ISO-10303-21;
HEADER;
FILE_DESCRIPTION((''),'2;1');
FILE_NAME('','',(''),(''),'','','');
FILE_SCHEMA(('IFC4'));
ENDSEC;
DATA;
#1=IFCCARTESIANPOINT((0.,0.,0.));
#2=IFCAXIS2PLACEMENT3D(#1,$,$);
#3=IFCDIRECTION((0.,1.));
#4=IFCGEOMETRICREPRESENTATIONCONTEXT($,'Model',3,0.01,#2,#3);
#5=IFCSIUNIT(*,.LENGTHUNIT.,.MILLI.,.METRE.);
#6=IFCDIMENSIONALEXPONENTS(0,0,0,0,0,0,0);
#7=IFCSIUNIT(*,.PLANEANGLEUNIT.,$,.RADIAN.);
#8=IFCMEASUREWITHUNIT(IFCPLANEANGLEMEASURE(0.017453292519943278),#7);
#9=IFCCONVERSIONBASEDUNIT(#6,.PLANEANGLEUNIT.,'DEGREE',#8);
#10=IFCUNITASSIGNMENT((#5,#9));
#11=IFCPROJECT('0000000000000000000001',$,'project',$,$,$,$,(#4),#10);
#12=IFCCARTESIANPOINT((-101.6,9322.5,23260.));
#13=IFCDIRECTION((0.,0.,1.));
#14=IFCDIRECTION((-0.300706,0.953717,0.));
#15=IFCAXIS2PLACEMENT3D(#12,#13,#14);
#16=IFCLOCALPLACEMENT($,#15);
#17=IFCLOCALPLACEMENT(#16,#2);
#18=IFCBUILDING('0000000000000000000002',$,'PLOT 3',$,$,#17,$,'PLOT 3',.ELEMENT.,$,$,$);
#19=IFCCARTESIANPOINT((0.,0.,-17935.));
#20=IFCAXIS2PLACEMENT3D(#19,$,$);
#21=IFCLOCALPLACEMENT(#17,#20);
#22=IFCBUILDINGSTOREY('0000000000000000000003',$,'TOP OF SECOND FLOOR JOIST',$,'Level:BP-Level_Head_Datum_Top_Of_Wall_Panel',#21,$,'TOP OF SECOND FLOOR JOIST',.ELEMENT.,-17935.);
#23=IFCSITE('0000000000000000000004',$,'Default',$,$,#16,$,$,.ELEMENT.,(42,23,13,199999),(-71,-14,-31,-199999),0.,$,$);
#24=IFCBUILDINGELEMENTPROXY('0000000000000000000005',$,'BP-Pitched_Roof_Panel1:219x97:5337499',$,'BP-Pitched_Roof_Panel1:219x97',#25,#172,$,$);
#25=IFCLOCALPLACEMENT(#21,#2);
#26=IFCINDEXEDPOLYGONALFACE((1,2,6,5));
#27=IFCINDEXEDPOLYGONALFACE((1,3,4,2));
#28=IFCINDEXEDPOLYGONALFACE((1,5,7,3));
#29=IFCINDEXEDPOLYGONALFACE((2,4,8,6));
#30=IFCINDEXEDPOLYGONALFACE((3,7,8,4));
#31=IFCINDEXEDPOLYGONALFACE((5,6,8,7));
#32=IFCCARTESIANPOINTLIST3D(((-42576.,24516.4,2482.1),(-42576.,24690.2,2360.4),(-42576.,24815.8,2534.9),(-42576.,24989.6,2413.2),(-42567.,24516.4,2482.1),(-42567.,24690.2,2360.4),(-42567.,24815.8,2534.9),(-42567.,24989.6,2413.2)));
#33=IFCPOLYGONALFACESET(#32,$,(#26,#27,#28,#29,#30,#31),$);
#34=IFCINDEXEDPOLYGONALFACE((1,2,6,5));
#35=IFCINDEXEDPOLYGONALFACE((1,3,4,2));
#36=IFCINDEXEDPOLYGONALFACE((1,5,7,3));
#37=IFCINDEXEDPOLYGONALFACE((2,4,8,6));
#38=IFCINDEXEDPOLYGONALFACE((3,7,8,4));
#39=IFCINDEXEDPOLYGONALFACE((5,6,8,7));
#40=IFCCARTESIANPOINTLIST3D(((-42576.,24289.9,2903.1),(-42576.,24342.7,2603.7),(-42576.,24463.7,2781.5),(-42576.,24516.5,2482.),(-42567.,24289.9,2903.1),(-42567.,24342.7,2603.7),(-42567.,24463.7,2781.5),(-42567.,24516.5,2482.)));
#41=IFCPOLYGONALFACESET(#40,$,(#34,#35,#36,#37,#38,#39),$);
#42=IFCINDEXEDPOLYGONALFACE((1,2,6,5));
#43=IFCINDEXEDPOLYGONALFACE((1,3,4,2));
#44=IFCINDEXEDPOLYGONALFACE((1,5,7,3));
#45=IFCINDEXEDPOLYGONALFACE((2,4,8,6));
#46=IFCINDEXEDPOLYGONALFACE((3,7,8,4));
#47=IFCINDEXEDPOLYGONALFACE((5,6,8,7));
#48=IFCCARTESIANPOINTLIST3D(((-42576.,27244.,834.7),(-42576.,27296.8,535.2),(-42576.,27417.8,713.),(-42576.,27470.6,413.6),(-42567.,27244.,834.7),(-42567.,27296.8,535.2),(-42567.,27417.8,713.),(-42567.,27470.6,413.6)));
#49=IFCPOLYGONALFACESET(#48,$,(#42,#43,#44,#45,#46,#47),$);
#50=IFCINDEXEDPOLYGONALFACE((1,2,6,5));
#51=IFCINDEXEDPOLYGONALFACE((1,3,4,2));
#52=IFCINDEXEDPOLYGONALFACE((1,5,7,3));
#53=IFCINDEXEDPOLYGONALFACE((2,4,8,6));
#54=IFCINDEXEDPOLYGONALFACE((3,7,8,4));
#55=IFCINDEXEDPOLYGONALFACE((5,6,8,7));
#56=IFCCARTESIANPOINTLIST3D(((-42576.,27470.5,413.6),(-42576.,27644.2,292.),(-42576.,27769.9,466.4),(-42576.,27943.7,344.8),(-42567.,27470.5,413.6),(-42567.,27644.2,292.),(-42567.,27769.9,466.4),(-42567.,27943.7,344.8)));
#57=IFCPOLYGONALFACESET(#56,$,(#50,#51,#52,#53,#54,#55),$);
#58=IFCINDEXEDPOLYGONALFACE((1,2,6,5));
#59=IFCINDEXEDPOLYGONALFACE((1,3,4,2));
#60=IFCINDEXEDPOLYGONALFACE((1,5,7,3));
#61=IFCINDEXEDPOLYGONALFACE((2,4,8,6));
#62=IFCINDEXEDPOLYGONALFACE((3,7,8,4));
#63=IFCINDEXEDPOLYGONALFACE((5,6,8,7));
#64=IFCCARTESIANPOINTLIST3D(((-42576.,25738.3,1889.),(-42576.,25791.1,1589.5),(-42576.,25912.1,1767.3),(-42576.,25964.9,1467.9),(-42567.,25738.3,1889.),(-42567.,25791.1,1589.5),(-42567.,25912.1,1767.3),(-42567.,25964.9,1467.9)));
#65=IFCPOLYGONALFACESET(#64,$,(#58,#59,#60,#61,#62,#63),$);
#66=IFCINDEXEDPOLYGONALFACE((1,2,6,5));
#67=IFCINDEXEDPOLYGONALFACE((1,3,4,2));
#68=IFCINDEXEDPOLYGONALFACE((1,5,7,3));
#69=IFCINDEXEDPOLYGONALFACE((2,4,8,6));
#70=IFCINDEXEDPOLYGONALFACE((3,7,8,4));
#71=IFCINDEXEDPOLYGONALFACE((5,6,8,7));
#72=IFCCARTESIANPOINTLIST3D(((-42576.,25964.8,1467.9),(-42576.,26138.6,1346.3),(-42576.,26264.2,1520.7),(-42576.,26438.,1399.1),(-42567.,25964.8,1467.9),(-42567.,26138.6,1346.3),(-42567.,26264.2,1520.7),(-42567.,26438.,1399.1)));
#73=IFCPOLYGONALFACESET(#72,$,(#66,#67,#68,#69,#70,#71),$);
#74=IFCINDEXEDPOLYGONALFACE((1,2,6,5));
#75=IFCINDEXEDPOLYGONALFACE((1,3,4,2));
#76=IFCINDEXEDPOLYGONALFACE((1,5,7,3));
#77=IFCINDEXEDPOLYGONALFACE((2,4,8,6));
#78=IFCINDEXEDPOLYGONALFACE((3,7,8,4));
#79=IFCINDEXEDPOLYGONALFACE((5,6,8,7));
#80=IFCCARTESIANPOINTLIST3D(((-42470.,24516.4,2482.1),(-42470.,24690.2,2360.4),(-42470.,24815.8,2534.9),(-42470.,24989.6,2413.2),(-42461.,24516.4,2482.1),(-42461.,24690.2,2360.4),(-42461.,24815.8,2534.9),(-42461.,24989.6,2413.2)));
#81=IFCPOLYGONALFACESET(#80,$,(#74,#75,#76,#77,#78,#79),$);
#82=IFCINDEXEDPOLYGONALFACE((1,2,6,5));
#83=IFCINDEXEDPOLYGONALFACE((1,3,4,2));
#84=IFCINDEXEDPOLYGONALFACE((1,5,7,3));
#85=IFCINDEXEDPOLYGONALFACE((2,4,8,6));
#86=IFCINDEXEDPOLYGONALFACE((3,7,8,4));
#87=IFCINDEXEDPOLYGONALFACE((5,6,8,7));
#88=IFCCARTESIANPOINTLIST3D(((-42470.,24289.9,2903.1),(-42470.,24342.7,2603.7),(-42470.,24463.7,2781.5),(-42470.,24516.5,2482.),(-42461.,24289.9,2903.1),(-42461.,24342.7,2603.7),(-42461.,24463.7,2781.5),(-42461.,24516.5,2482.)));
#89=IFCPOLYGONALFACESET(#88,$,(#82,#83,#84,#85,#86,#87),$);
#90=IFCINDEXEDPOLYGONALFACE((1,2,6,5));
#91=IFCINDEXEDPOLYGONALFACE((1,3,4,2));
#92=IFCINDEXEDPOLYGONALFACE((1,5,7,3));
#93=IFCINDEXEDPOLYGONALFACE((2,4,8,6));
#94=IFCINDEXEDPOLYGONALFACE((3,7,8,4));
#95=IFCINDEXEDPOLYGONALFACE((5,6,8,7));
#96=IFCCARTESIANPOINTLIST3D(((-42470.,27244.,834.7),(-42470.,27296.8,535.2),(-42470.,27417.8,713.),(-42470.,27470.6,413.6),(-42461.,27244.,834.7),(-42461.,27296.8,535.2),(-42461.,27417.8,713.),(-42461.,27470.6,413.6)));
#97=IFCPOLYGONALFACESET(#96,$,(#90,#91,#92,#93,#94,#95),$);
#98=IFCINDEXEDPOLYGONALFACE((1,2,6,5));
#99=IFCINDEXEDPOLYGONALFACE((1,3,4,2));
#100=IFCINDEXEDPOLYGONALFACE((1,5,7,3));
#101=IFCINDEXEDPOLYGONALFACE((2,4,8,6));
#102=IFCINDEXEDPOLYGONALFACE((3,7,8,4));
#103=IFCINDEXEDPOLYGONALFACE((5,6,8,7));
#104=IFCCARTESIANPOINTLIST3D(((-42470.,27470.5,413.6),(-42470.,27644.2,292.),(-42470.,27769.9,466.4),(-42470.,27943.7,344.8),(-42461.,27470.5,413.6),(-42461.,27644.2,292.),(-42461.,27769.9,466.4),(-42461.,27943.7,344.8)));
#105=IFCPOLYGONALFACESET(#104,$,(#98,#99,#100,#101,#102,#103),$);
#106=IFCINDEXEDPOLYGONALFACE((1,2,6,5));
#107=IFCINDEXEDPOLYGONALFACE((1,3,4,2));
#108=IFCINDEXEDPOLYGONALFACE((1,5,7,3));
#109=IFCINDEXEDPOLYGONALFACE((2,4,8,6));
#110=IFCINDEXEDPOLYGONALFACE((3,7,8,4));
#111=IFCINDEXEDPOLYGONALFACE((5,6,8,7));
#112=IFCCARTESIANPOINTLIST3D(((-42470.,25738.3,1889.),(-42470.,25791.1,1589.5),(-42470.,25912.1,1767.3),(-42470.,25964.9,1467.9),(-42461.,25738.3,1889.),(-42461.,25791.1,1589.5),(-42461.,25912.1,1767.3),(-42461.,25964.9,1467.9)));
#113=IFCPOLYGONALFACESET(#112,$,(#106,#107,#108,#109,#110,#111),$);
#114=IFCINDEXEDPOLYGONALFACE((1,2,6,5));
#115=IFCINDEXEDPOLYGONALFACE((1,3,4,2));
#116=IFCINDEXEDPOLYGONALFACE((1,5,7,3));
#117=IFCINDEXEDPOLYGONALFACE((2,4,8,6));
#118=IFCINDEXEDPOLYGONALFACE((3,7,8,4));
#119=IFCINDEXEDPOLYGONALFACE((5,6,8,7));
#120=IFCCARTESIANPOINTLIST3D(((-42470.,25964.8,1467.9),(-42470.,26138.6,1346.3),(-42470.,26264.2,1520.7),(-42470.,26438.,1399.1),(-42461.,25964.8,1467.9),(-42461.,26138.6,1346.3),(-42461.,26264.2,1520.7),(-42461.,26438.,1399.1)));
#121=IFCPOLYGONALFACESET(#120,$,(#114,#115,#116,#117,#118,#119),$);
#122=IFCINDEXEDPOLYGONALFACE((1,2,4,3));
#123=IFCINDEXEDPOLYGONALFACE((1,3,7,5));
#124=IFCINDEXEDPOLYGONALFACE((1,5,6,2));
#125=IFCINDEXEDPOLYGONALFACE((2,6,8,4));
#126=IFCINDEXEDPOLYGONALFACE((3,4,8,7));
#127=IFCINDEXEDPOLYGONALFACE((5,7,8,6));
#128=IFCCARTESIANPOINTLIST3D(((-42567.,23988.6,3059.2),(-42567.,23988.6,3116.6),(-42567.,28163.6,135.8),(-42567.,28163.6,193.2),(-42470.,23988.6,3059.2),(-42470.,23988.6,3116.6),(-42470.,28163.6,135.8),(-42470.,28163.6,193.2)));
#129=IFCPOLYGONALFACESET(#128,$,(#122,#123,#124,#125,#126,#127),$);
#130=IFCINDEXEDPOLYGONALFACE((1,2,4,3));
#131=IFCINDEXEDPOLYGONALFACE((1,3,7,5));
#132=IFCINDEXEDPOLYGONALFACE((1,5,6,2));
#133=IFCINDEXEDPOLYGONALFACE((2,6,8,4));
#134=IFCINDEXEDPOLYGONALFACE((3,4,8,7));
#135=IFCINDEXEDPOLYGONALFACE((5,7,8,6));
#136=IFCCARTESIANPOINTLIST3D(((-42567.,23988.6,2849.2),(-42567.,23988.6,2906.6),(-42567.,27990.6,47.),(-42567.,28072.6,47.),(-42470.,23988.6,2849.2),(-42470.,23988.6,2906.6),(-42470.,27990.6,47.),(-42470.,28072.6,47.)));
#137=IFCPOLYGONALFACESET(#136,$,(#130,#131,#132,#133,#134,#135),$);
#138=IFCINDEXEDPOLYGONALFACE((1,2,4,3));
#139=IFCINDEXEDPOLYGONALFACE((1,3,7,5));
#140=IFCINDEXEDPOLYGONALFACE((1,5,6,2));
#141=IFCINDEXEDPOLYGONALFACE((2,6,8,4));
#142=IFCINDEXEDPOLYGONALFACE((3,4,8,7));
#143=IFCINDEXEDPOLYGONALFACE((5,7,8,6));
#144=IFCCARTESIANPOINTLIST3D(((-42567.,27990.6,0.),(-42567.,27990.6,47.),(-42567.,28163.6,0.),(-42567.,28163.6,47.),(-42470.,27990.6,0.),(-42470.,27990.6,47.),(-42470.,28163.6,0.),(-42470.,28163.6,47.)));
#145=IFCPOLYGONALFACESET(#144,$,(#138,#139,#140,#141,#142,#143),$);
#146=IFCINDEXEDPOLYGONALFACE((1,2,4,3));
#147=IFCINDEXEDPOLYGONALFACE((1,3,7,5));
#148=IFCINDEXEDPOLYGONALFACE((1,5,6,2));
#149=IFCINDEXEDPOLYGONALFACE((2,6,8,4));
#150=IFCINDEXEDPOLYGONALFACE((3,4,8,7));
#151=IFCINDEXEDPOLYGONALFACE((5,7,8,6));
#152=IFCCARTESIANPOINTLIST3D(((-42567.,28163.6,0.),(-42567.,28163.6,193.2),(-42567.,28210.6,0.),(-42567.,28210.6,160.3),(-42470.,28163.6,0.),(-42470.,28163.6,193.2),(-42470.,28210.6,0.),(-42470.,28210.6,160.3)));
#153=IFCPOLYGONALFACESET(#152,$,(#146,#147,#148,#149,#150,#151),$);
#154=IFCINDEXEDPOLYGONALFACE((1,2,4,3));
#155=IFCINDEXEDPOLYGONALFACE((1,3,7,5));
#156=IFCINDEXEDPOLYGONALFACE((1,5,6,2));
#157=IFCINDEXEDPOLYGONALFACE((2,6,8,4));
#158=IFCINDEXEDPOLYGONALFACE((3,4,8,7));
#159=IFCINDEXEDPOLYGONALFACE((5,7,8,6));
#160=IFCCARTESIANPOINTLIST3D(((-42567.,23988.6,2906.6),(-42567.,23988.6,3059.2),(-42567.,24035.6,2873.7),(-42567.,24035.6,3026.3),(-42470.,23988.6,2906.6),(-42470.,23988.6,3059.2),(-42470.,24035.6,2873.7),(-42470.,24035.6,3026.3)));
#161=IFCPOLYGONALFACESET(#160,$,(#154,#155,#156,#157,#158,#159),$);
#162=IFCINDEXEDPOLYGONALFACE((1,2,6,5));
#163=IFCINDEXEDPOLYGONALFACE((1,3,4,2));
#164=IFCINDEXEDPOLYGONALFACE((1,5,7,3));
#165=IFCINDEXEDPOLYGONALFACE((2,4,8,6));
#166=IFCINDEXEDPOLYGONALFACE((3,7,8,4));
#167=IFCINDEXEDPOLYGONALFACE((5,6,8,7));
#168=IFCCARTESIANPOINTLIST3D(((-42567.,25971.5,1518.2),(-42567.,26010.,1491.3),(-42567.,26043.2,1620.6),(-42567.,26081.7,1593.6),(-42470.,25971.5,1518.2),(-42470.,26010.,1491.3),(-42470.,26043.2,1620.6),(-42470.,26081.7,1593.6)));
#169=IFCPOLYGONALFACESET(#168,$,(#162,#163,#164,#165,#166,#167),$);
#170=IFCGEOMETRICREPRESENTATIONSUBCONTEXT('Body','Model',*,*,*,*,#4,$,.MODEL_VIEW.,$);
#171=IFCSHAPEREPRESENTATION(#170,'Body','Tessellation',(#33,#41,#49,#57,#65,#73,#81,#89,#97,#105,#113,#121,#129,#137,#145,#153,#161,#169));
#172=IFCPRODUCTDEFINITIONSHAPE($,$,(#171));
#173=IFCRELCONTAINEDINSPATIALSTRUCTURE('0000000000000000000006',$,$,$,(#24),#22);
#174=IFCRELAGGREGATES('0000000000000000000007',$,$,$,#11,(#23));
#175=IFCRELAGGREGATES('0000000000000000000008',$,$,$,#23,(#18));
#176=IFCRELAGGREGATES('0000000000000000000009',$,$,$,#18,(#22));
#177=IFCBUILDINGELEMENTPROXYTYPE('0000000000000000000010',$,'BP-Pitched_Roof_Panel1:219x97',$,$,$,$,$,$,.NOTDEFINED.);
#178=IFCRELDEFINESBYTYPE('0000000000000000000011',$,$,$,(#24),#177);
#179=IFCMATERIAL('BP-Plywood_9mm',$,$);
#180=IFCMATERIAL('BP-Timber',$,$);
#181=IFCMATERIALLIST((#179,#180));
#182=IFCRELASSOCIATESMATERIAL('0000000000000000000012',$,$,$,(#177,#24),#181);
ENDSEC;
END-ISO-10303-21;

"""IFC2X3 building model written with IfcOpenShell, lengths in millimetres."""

from ifc_helpers import new_model, entity, si_unit, converted_unit, direction, frame, frame_2d, origin, origin_2d_with_axis, place, context, subcontext, project, spatial, polyline, rectangle, outline, extrude, source, transform, mapped, material, material_list, type_object, type_shapes, element, save


model = new_model("IFC2X3")

# Units and contexts
model_context = context("Model", 3, precision=0.01, world=origin(), true_north=direction((0.0, 1.0)))
body_context = subcontext(model_context, "Body", "Model", "MODEL_VIEW")
ifc_project = project(units=[si_unit("LENGTHUNIT", "METRE", prefix="MILLI"), converted_unit("PLANEANGLEUNIT", "DEGREE", entity("IfcPlaneAngleMeasure", 0.017453292519943278), si_unit("PLANEANGLEUNIT", "RADIAN"), dimensions=[0, 0, 0, 0, 0, 0, 0])], contexts=[model_context])

# Site, building, storey
site_placement = place(None, frame((-101.6, 9322.5, 23260.0), z_axis=(0.0, 0.0, 1.0), x_axis=(-0.300706, 0.953717, 0.0)))
site = spatial("IfcSite", under=ifc_project, at=site_placement, Name="Default", CompositionType="ELEMENT", RefLatitude=(42, 23, 13, 199999), RefLongitude=(-71, -14, -31, -199999), RefElevation=0.0)
building_placement = place(site_placement, origin())
building = spatial("IfcBuilding", under=site, at=building_placement, Name="PLOT 3", LongName="PLOT 3", CompositionType="ELEMENT")
storey_placement = place(building_placement, frame((0.0, 0.0, -17935.0)))
storey = spatial("IfcBuildingStorey", under=building, at=storey_placement, Name="TOP OF SECOND FLOOR JOIST", ObjectType="Level:BP-Level_Head_Datum_Top_Of_Wall_Panel", LongName="TOP OF SECOND FLOOR JOIST", CompositionType="ELEMENT", Elevation=-17935.0)

# Building element proxy
ifc_material_1 = material(Name="BP-Timber")
ifc_material_2 = material(Name="BP-Plywood_9mm")
ifc_material_list = material_list([ifc_material_2, ifc_material_1])
building_element_proxy_type_1 = type_object("IfcBuildingElementProxyType", Name="BP-Pitched_Roof_Panel1:219x97", PredefinedType="NOTDEFINED", material=ifc_material_list)
shared_shape_1 = source(origin(), body_context, "Body", "SweptSolid", [
    extrude(outline(polyline([(-77.0, -75.0), (227.0, -75.0), (77.0, 75.0), (-227.0, 75.0), (-77.0, -75.0)])), frame((35.3, -3956.0, 2447.7), z_axis=(0.0, 1.0, 0.0), x_axis=(-0.984808, 0.0, 0.173648)), (0.0, 0.0, 1.0), 9.0),
    extrude(outline(polyline([(1.4, -107.5), (213.6, -107.5), (-1.4, 107.5), (-213.6, 107.5), (1.4, -107.5)])), frame((385.1, -3956.0, 2692.6), z_axis=(0.0, 1.0, 0.0), x_axis=(-0.819152, 0.0, -0.573576)), (0.0, 0.0, 1.0), 9.0),
    extrude(outline(polyline([(1.4, -107.5), (213.6, -107.5), (-1.4, 107.5), (-213.6, 107.5), (1.4, -107.5)])), frame((-2569.0, -3956.0, 624.1), z_axis=(0.0, 1.0, 0.0), x_axis=(-0.819152, 0.0, -0.573576)), (0.0, 0.0, 1.0), 9.0),
    extrude(outline(polyline([(-77.0, -75.0), (227.0, -75.0), (77.0, 75.0), (-227.0, 75.0), (-77.0, -75.0)])), frame((-2918.8, -3956.0, 379.2), z_axis=(0.0, 1.0, 0.0), x_axis=(-0.984808, 0.0, 0.173648)), (0.0, 0.0, 1.0), 9.0),
    extrude(outline(polyline([(1.4, -107.5), (213.6, -107.5), (-1.4, 107.5), (-213.6, 107.5), (1.4, -107.5)])), frame((-1063.3, -3956.0, 1678.4), z_axis=(0.0, 1.0, 0.0), x_axis=(-0.819152, 0.0, -0.573576)), (0.0, 0.0, 1.0), 9.0),
    extrude(outline(polyline([(-77.0, -75.0), (227.0, -75.0), (77.0, 75.0), (-227.0, 75.0), (-77.0, -75.0)])), frame((-1413.1, -3956.0, 1433.5), z_axis=(0.0, 1.0, 0.0), x_axis=(-0.984808, 0.0, 0.173648)), (0.0, 0.0, 1.0), 9.0),
    extrude(outline(polyline([(-77.0, -75.0), (227.0, -75.0), (77.0, 75.0), (-227.0, 75.0), (-77.0, -75.0)])), frame((35.3, -3850.0, 2447.7), z_axis=(0.0, 1.0, 0.0), x_axis=(-0.984808, 0.0, 0.173648)), (0.0, 0.0, 1.0), 9.0),
    extrude(outline(polyline([(1.4, -107.5), (213.6, -107.5), (-1.4, 107.5), (-213.6, 107.5), (1.4, -107.5)])), frame((385.1, -3850.0, 2692.6), z_axis=(0.0, 1.0, 0.0), x_axis=(-0.819152, 0.0, -0.573576)), (0.0, 0.0, 1.0), 9.0),
    extrude(outline(polyline([(1.4, -107.5), (213.6, -107.5), (-1.4, 107.5), (-213.6, 107.5), (1.4, -107.5)])), frame((-2569.0, -3850.0, 624.1), z_axis=(0.0, 1.0, 0.0), x_axis=(-0.819152, 0.0, -0.573576)), (0.0, 0.0, 1.0), 9.0),
    extrude(outline(polyline([(-77.0, -75.0), (227.0, -75.0), (77.0, 75.0), (-227.0, 75.0), (-77.0, -75.0)])), frame((-2918.8, -3850.0, 379.2), z_axis=(0.0, 1.0, 0.0), x_axis=(-0.984808, 0.0, 0.173648)), (0.0, 0.0, 1.0), 9.0),
    extrude(outline(polyline([(1.4, -107.5), (213.6, -107.5), (-1.4, 107.5), (-213.6, 107.5), (1.4, -107.5)])), frame((-1063.3, -3850.0, 1678.4), z_axis=(0.0, 1.0, 0.0), x_axis=(-0.819152, 0.0, -0.573576)), (0.0, 0.0, 1.0), 9.0),
    extrude(outline(polyline([(-77.0, -75.0), (227.0, -75.0), (77.0, 75.0), (-227.0, 75.0), (-77.0, -75.0)])), frame((-1413.1, -3850.0, 1433.5), z_axis=(0.0, 1.0, 0.0), x_axis=(-0.984808, 0.0, 0.173648)), (0.0, 0.0, 1.0), 9.0),
    extrude(outline(polyline([(-1490.4, -2087.5), (-1433.0, -2087.5), (1490.4, 2087.5), (1433.0, 2087.5), (-1490.4, -2087.5)])), frame((-1287.8, -3947.0, 1626.2), z_axis=(0.0, 1.0, 0.0), x_axis=(0.0, 0.0, -1.0)), (0.0, 0.0, 1.0), 97.0),
    extrude(outline(polyline([(-1444.1, -2021.5), (-1386.8, -2021.5), (1415.5, 1980.5), (1415.5, 2062.5), (-1444.1, -2021.5)])), frame((-1221.8, -3947.0, 1462.5), z_axis=(0.0, 1.0, 0.0), x_axis=(0.0, 0.0, -1.0)), (0.0, 0.0, 1.0), 97.0),
    extrude(rectangle(XDim=173.0, YDim=97.0, at=origin_2d_with_axis()), frame((-3288.8, -3898.5, 0.0), z_axis=(0.0, 0.0, 1.0), x_axis=(-1.0, 0.0, 0.0)), (0.0, 0.0, 1.0), 47.0),
    extrude(outline(polyline([(22.0, -72.4), (79.4, -72.4), (-31.4, 85.9), (-69.9, 58.9), (22.0, -72.4)])), frame((-3398.8, -3947.0, 88.4), z_axis=(0.0, 1.0, 0.0), x_axis=(0.819152, 0.0, 0.573576)), (0.0, 0.0, 1.0), 97.0),
    extrude(outline(polyline([(15.1, -62.5), (72.5, -62.5), (-15.1, 62.5), (-72.5, 62.5), (15.1, -62.5)])), frame((776.2, -3947.0, 2966.5), z_axis=(0.0, 1.0, 0.0), x_axis=(0.819152, 0.0, 0.573576)), (0.0, 0.0, 1.0), 97.0),
    extrude(rectangle(XDim=47.0, YDim=97.0, at=frame_2d((0.0, 0.0), x_axis=(1.0, 0.0))), frame((-1202.4, -3898.5, 1504.7), z_axis=(-0.573576, 0.0, 0.819152), x_axis=(-0.819152, 0.0, -0.573576)), (0.0, 0.0, 1.0), 125.0),
])
type_shapes(building_element_proxy_type_1, [shared_shape_1])
for number, where, z_axis, x_axis, name in (
    (1, (-38620.0, 24788.3, 0.0), (0.0, 0.0, 1.0), (0.0, -1.0, 0.0), "BP-Pitched_Roof_Panel1:219x97:5337499"),
):
    element("IfcBuildingElementProxy", number, at=place(storey_placement, frame(where, z_axis=z_axis, x_axis=x_axis)), inside=storey, type_object=building_element_proxy_type_1, material=ifc_material_list, Name=name, ObjectType="BP-Pitched_Roof_Panel1:219x97", context=body_context, shape_type="MappedRepresentation", body=[
        mapped(shared_shape_1, transform((0.0, 0.0, 0.0), scale=1.0)),
    ])

save(model, "model.ifc")
